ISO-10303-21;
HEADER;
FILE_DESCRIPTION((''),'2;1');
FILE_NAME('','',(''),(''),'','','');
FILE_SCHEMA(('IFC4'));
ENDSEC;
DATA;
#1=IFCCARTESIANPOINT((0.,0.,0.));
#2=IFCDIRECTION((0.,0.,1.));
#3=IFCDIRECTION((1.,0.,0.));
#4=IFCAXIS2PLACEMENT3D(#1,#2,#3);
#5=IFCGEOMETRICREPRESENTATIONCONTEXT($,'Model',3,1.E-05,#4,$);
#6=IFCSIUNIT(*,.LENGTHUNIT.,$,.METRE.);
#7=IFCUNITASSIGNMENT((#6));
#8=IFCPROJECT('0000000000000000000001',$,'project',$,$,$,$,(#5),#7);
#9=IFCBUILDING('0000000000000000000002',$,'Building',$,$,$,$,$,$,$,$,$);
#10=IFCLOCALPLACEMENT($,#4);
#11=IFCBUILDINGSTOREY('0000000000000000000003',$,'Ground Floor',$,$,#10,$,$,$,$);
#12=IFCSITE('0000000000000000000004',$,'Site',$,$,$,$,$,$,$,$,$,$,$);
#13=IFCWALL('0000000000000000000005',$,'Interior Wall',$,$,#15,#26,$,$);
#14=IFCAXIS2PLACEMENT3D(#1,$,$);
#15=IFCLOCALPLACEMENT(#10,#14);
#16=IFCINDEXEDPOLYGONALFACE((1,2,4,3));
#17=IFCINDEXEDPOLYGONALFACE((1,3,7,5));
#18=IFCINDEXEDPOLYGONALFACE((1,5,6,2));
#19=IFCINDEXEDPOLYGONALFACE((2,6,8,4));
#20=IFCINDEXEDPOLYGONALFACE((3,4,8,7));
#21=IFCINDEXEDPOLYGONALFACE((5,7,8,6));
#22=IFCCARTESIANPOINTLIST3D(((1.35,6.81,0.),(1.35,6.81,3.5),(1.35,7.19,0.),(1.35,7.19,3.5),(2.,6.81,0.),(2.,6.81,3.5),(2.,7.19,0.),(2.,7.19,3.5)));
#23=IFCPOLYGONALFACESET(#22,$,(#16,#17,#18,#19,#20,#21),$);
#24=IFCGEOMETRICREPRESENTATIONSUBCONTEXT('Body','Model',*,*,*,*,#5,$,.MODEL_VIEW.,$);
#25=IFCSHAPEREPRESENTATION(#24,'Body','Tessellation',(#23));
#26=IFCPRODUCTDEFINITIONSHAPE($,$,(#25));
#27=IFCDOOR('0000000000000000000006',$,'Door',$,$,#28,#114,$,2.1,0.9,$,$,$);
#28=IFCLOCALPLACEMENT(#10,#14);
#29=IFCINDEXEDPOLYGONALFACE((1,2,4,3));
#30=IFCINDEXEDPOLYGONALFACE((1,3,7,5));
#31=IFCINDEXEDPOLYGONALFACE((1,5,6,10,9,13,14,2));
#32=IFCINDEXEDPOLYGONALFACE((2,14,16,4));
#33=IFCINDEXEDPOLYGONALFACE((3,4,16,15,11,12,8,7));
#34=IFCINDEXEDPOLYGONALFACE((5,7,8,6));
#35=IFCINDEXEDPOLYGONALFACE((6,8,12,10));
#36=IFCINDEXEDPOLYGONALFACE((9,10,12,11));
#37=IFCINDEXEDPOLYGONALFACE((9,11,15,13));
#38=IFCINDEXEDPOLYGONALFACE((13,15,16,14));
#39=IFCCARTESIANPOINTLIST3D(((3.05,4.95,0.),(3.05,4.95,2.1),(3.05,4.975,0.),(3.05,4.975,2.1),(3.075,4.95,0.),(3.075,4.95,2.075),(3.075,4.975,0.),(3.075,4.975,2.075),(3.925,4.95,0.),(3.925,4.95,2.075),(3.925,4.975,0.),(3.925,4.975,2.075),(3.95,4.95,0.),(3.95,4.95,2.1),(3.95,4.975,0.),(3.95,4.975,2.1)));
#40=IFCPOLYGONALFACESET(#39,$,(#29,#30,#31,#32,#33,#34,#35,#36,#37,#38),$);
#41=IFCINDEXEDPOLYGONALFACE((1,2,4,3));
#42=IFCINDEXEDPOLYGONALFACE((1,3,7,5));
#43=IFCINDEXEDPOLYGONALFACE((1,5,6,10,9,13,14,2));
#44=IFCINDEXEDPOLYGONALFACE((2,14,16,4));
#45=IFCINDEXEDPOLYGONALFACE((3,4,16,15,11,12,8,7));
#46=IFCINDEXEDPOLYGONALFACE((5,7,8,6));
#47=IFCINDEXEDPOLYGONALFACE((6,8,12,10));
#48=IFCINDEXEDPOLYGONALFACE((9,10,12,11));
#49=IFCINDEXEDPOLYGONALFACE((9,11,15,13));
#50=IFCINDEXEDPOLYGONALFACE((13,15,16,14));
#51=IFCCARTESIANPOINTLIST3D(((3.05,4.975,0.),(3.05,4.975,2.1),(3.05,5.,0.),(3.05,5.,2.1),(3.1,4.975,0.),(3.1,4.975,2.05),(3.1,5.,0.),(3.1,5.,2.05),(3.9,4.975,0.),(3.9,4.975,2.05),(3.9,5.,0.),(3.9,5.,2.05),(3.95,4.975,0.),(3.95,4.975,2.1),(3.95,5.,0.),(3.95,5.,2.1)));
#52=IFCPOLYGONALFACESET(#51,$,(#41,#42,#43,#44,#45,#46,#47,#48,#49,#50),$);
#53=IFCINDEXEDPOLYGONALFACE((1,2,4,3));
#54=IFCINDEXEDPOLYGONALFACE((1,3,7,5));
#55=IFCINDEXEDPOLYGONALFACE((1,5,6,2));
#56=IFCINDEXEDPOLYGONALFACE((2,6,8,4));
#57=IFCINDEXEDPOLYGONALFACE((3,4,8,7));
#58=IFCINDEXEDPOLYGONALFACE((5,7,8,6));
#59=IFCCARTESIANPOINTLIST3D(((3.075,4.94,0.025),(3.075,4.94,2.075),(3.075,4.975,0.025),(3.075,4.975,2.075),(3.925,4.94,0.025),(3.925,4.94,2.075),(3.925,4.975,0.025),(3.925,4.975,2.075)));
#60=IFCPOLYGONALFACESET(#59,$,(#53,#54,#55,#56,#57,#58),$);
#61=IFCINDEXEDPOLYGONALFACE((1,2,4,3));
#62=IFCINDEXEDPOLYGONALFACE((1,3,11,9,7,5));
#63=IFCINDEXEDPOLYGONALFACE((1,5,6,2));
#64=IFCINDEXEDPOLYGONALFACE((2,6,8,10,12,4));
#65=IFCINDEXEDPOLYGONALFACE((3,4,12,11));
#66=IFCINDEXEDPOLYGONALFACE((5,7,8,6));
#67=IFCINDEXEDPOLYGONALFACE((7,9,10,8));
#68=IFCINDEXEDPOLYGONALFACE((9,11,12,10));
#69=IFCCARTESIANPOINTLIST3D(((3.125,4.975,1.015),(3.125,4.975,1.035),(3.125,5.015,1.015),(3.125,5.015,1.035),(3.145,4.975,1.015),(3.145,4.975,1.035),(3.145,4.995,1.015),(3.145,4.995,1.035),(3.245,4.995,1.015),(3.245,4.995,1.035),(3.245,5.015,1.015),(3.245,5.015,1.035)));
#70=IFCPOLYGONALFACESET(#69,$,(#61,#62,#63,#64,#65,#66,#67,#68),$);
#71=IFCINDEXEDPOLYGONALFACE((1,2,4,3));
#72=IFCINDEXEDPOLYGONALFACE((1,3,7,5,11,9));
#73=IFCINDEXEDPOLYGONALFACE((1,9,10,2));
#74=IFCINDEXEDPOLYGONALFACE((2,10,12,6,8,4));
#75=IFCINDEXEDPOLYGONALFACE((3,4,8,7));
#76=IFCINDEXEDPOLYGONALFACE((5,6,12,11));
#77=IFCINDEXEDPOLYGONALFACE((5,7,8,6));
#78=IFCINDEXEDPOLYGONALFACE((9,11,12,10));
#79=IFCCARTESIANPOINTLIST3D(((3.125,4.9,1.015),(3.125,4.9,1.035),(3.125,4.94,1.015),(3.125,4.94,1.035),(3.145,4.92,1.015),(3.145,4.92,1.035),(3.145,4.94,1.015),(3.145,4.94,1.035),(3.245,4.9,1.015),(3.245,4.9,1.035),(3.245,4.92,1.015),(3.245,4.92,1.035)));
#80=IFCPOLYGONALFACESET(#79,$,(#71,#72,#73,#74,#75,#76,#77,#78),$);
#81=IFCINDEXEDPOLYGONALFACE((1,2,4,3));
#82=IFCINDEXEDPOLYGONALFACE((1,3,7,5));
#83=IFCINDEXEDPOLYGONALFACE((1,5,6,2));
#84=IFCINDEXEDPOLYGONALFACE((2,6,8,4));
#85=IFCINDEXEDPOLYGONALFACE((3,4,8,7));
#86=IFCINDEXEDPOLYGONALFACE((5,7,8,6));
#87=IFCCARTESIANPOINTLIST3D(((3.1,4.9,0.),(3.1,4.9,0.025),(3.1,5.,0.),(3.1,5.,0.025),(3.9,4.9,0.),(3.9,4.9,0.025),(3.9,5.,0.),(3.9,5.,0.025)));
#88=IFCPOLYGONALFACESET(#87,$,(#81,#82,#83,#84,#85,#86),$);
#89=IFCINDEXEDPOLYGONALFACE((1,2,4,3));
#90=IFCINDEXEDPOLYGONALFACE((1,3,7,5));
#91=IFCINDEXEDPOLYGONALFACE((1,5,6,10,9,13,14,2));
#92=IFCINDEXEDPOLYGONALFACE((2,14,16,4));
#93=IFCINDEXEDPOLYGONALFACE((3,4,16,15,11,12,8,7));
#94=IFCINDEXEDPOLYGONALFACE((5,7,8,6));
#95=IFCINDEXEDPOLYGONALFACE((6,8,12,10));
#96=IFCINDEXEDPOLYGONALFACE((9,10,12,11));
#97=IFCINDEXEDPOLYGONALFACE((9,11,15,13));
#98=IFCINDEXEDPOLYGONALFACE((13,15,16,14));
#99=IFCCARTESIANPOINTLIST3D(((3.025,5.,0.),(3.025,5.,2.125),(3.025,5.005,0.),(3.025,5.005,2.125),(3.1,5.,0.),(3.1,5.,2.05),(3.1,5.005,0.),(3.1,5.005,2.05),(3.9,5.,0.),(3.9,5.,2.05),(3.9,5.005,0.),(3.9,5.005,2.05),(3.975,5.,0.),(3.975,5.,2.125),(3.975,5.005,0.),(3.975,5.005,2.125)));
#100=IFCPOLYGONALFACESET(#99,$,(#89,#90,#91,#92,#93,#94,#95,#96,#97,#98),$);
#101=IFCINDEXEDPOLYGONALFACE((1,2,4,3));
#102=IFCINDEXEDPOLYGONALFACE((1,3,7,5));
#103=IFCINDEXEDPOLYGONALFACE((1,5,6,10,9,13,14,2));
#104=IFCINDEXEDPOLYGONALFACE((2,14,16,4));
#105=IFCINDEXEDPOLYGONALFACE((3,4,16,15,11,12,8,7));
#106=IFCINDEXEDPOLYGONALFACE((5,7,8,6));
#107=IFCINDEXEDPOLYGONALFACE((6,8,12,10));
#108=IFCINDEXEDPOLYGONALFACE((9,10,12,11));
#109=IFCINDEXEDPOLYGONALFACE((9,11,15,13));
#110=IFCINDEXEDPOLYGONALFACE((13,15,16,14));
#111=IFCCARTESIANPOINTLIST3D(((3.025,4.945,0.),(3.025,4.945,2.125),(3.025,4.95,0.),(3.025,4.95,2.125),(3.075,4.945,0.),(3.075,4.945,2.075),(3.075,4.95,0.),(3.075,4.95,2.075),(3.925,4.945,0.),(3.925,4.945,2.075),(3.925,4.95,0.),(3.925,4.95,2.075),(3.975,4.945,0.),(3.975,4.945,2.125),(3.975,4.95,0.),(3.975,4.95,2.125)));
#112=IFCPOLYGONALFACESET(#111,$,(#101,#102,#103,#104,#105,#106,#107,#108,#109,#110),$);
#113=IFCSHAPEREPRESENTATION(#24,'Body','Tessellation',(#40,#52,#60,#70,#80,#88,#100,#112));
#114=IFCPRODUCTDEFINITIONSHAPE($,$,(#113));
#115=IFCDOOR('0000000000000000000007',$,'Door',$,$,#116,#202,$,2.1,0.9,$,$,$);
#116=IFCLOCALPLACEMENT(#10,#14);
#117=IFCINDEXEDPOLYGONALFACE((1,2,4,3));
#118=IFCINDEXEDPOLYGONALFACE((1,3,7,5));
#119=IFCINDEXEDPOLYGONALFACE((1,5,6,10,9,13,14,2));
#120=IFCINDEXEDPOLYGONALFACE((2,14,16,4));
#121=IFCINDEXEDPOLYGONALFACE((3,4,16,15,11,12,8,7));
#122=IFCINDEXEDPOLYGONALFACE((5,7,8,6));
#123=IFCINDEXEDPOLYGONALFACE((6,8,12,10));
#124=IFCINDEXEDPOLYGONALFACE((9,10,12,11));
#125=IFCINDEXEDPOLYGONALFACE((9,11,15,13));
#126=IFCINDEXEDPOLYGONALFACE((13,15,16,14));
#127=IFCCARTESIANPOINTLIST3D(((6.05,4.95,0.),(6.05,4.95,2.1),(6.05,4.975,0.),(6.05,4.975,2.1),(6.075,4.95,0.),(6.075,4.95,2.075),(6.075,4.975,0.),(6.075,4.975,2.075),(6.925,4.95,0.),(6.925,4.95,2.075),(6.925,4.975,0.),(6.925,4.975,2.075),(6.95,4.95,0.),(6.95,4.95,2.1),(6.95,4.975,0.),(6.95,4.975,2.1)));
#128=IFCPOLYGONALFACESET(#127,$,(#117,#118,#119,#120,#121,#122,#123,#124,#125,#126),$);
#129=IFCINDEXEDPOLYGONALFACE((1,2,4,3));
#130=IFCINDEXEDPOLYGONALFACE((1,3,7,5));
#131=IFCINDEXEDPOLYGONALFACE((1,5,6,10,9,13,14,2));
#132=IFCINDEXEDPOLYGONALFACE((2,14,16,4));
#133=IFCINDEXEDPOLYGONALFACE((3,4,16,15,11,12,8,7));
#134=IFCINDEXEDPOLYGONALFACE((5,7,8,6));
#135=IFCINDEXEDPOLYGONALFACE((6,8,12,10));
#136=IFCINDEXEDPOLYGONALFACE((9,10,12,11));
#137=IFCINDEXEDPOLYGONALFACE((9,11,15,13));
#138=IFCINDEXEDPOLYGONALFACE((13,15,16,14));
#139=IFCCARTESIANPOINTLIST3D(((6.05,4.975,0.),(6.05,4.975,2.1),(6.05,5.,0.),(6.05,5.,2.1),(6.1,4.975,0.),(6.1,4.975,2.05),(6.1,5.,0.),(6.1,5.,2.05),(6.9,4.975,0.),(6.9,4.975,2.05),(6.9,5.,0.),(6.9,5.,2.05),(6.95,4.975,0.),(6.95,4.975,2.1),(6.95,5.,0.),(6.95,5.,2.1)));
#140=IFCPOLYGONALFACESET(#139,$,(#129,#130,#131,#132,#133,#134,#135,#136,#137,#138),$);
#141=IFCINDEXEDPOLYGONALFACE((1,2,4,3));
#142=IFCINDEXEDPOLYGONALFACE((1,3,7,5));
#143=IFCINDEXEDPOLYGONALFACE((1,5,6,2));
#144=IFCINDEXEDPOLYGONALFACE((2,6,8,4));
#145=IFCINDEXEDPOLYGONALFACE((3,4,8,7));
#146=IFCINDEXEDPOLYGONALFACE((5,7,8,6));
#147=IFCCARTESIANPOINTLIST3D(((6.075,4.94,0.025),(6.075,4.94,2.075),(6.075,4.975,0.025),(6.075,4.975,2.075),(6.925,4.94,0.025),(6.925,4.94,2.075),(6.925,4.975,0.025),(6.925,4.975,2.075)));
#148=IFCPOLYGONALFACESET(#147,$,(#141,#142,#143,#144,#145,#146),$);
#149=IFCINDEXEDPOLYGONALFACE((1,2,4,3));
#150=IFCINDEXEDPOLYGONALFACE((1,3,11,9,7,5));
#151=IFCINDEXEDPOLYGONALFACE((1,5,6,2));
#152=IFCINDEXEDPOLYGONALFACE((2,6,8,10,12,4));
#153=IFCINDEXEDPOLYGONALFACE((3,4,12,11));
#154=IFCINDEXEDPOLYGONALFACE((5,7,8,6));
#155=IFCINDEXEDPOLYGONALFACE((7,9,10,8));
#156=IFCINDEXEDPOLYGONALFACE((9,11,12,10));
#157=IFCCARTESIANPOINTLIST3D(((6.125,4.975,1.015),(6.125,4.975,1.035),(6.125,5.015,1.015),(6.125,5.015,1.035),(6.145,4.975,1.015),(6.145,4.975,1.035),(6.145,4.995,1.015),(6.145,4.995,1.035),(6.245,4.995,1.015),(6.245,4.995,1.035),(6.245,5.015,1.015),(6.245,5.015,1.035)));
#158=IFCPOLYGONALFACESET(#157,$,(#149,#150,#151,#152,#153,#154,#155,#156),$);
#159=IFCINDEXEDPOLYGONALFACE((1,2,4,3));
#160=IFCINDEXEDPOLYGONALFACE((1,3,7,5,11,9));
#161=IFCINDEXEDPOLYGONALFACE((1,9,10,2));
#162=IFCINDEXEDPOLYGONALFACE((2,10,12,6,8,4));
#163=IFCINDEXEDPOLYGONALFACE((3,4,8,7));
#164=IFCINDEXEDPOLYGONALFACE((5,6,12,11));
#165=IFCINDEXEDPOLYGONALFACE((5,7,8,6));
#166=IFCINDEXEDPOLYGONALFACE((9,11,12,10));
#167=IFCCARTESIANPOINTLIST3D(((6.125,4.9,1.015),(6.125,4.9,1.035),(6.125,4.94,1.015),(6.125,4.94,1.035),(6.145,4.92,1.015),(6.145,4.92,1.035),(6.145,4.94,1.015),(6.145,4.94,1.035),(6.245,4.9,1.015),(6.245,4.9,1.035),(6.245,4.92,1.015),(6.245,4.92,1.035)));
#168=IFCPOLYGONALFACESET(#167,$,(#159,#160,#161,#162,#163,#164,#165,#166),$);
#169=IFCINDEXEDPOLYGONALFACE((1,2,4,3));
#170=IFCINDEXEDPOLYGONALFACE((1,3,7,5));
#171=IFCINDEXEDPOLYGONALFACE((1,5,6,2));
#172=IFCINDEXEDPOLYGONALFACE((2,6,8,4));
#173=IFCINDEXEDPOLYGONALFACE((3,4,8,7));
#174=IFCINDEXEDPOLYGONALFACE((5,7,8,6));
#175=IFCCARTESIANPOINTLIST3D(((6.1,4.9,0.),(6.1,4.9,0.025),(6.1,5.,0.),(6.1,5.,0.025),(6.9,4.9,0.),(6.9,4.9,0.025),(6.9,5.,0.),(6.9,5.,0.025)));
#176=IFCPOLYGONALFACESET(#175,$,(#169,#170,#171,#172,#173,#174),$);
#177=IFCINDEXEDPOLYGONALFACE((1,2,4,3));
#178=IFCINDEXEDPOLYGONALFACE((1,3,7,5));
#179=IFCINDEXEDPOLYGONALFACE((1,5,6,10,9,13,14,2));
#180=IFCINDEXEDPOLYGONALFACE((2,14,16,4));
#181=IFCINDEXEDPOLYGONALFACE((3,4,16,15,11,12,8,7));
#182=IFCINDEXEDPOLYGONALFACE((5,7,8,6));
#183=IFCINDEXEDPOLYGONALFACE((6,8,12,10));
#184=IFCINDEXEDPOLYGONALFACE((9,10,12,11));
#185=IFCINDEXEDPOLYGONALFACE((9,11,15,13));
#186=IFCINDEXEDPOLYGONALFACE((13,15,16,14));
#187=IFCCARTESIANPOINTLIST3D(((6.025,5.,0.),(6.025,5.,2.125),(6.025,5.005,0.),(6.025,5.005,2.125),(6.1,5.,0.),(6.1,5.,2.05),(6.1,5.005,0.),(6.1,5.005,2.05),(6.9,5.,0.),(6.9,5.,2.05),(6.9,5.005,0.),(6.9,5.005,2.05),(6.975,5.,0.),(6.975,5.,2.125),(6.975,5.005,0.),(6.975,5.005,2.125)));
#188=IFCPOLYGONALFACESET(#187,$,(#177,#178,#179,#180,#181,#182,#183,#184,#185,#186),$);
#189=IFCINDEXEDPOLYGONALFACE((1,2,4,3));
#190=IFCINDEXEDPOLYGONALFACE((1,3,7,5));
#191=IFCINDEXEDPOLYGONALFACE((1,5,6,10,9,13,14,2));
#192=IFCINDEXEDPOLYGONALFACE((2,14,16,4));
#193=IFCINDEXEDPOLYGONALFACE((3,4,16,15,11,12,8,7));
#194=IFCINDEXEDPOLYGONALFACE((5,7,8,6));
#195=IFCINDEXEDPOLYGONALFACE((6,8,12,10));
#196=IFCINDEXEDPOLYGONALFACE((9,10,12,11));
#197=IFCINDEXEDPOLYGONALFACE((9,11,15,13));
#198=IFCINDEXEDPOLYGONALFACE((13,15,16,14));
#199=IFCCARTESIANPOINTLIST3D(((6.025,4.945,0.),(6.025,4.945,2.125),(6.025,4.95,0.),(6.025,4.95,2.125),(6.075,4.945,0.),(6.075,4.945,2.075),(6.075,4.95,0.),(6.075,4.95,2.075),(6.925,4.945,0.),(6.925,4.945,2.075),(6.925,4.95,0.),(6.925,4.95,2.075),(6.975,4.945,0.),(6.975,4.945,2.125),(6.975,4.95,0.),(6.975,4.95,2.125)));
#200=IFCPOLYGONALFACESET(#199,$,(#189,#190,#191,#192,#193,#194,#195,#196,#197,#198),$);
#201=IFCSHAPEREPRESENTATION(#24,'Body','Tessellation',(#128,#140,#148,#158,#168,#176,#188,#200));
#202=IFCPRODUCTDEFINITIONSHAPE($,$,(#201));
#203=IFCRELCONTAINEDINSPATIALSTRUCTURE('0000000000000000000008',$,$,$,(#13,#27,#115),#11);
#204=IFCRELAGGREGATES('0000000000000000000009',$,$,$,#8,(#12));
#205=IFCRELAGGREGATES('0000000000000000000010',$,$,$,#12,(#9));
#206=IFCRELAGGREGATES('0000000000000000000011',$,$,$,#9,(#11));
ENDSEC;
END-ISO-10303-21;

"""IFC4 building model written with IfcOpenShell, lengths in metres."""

from ifc_helpers import new_model, si_unit, frame, origin_with_axes, place, context, subcontext, project, spatial, line, indexed_curve, outline, extrude, element, save


model = new_model("IFC4")

# Units and contexts
model_context = context("Model", 3, precision=1e-05, world=origin_with_axes())
body_context = subcontext(model_context, "Body", "Model", "MODEL_VIEW")
ifc_project = project(units=[si_unit("LENGTHUNIT", "METRE")], contexts=[model_context])

# Site, building, storey
site = spatial("IfcSite", under=ifc_project, Name="Site")
building = spatial("IfcBuilding", under=site, Name="Building")
storey_placement = place(None, origin_with_axes())
storey = spatial("IfcBuildingStorey", under=building, at=storey_placement, Name="Ground Floor")

# Wall
wall_1_placement = place(storey_placement, frame((1.35, 7.0, 0.0), z_axis=(0.0, 0.0, 1.0), x_axis=(1.0, 0.0, 0.0)))
element("IfcWall", 1, at=wall_1_placement, inside=storey, Name="Interior Wall", context=body_context, shape_type="SweptSolid", body=[
    extrude(outline(indexed_curve([(0.0, 0.0), (0.0, 0.38), (0.65, 0.38), (0.65, 0.0), (0.0, 0.0)], self_intersect=False)), frame((0.0, -0.19, 0.0), z_axis=(0.0, 0.0, 1.0), x_axis=(1.0, 0.0, 0.0)), (0.0, 0.0, 1.0), 3.5),
])

# Doors
door_1_placement = place(storey_placement, frame((3.95, 5.0, 0.0), z_axis=(0.0, 0.0, 1.0), x_axis=(-1.0, 0.0, 0.0)))
element("IfcDoor", 2, at=door_1_placement, inside=storey, Name="Door", OverallHeight=2.1, OverallWidth=0.9, context=body_context, shape_type="SweptSolid", body=[
    extrude(outline(indexed_curve([(0.0, 0.0), (0.0, 2.1), (0.9, 2.1), (0.9, 0.0), (0.875, 0.0), (0.875, 2.075), (0.025, 2.075), (0.025, 0.0)], segments=[line(1, 2, 3, 4, 5, 6, 7, 8, 1)])), frame((0.0, 0.025, 0.0), z_axis=(0.0, -1.0, 0.0), x_axis=(1.0, 0.0, 0.0)), (0.0, 0.0, -1.0), 0.025),
    extrude(outline(indexed_curve([(0.0, 0.0), (0.0, 2.1), (0.9, 2.1), (0.9, 0.0), (0.85, 0.0), (0.85, 2.05), (0.05, 2.05), (0.05, 0.0)], segments=[line(1, 2, 3, 4, 5, 6, 7, 8, 1)])), frame((0.0, 0.0, 0.0), z_axis=(0.0, -1.0, 0.0), x_axis=(1.0, 0.0, 0.0)), (0.0, 0.0, -1.0), 0.025),
    extrude(outline(indexed_curve([(0.0, 0.0), (0.85, 0.0), (0.85, 0.035), (0.0, 0.035)], segments=[line(1, 2, 3, 4, 1)])), frame((0.025, 0.025, 0.025), z_axis=(0.0, 0.0, 1.0), x_axis=(1.0, 0.0, 0.0)), (0.0, 0.0, 1.0), 2.05),
    extrude(outline(indexed_curve([(0.0, 0.0), (0.0, -0.04), (-0.12, -0.04), (-0.12, -0.02), (-0.02, -0.02), (-0.02, 0.0)], segments=[line(1, 2, 3, 4, 5, 6, 1)])), frame((0.825, 0.025, 1.015), z_axis=(0.0, 0.0, 1.0), x_axis=(1.0, 0.0, 0.0)), (0.0, 0.0, 1.0), 0.02),
    extrude(outline(indexed_curve([(0.0, 0.0), (0.0, 0.04), (-0.12, 0.04), (-0.12, 0.02), (-0.02, 0.02), (-0.02, 0.0)], segments=[line(1, 2, 3, 4, 5, 6, 1)])), frame((0.825, 0.06, 1.015), z_axis=(0.0, 0.0, 1.0), x_axis=(1.0, 0.0, 0.0)), (0.0, 0.0, 1.0), 0.02),
    extrude(outline(indexed_curve([(0.0, 0.0), (0.8, 0.0), (0.8, 0.1), (0.0, 0.1)], segments=[line(1, 2, 3, 4, 1)])), frame((0.05, 0.0, 0.0), z_axis=(0.0, 0.0, 1.0), x_axis=(1.0, 0.0, 0.0)), (0.0, 0.0, 1.0), 0.025),
    extrude(outline(indexed_curve([(0.0, 0.0), (0.0, 2.125), (0.95, 2.125), (0.95, 0.0), (0.875, 0.0), (0.875, 2.05), (0.075, 2.05), (0.075, 0.0)], segments=[line(1, 2, 3, 4, 5, 6, 7, 8, 1)])), frame((-0.025, -0.005, 0.0), z_axis=(0.0, -1.0, 0.0), x_axis=(1.0, 0.0, 0.0)), (0.0, 0.0, -1.0), 0.005),
    extrude(outline(indexed_curve([(0.0, 0.0), (0.0, 2.125), (0.95, 2.125), (0.95, 0.0), (0.9, 0.0), (0.9, 2.075), (0.05, 2.075), (0.05, 0.0)], segments=[line(1, 2, 3, 4, 5, 6, 7, 8, 1)])), frame((-0.025, 0.05, 0.0), z_axis=(0.0, -1.0, 0.0), x_axis=(1.0, 0.0, 0.0)), (0.0, 0.0, -1.0), 0.005),
])
door_2_placement = place(storey_placement, frame((6.95, 5.0, 0.0), z_axis=(0.0, 0.0, 1.0), x_axis=(-1.0, 0.0, 0.0)))
element("IfcDoor", 3, at=door_2_placement, inside=storey, Name="Door", OverallHeight=2.1, OverallWidth=0.9, context=body_context, shape_type="SweptSolid", body=[
    extrude(outline(indexed_curve([(0.0, 0.0), (0.0, 2.1), (0.9, 2.1), (0.9, 0.0), (0.875, 0.0), (0.875, 2.075), (0.025, 2.075), (0.025, 0.0)], segments=[line(1, 2, 3, 4, 5, 6, 7, 8, 1)])), frame((0.0, 0.025, 0.0), z_axis=(0.0, -1.0, 0.0), x_axis=(1.0, 0.0, 0.0)), (0.0, 0.0, -1.0), 0.025),
    extrude(outline(indexed_curve([(0.0, 0.0), (0.0, 2.1), (0.9, 2.1), (0.9, 0.0), (0.85, 0.0), (0.85, 2.05), (0.05, 2.05), (0.05, 0.0)], segments=[line(1, 2, 3, 4, 5, 6, 7, 8, 1)])), frame((0.0, 0.0, 0.0), z_axis=(0.0, -1.0, 0.0), x_axis=(1.0, 0.0, 0.0)), (0.0, 0.0, -1.0), 0.025),
    extrude(outline(indexed_curve([(0.0, 0.0), (0.85, 0.0), (0.85, 0.035), (0.0, 0.035)], segments=[line(1, 2, 3, 4, 1)])), frame((0.025, 0.025, 0.025), z_axis=(0.0, 0.0, 1.0), x_axis=(1.0, 0.0, 0.0)), (0.0, 0.0, 1.0), 2.05),
    extrude(outline(indexed_curve([(0.0, 0.0), (0.0, -0.04), (-0.12, -0.04), (-0.12, -0.02), (-0.02, -0.02), (-0.02, 0.0)], segments=[line(1, 2, 3, 4, 5, 6, 1)])), frame((0.825, 0.025, 1.015), z_axis=(0.0, 0.0, 1.0), x_axis=(1.0, 0.0, 0.0)), (0.0, 0.0, 1.0), 0.02),
    extrude(outline(indexed_curve([(0.0, 0.0), (0.0, 0.04), (-0.12, 0.04), (-0.12, 0.02), (-0.02, 0.02), (-0.02, 0.0)], segments=[line(1, 2, 3, 4, 5, 6, 1)])), frame((0.825, 0.06, 1.015), z_axis=(0.0, 0.0, 1.0), x_axis=(1.0, 0.0, 0.0)), (0.0, 0.0, 1.0), 0.02),
    extrude(outline(indexed_curve([(0.0, 0.0), (0.8, 0.0), (0.8, 0.1), (0.0, 0.1)], segments=[line(1, 2, 3, 4, 1)])), frame((0.05, 0.0, 0.0), z_axis=(0.0, 0.0, 1.0), x_axis=(1.0, 0.0, 0.0)), (0.0, 0.0, 1.0), 0.025),
    extrude(outline(indexed_curve([(0.0, 0.0), (0.0, 2.125), (0.95, 2.125), (0.95, 0.0), (0.875, 0.0), (0.875, 2.05), (0.075, 2.05), (0.075, 0.0)], segments=[line(1, 2, 3, 4, 5, 6, 7, 8, 1)])), frame((-0.025, -0.005, 0.0), z_axis=(0.0, -1.0, 0.0), x_axis=(1.0, 0.0, 0.0)), (0.0, 0.0, -1.0), 0.005),
    extrude(outline(indexed_curve([(0.0, 0.0), (0.0, 2.125), (0.95, 2.125), (0.95, 0.0), (0.9, 0.0), (0.9, 2.075), (0.05, 2.075), (0.05, 0.0)], segments=[line(1, 2, 3, 4, 5, 6, 7, 8, 1)])), frame((-0.025, 0.05, 0.0), z_axis=(0.0, -1.0, 0.0), x_axis=(1.0, 0.0, 0.0)), (0.0, 0.0, -1.0), 0.005),
])

save(model, "model.ifc")
